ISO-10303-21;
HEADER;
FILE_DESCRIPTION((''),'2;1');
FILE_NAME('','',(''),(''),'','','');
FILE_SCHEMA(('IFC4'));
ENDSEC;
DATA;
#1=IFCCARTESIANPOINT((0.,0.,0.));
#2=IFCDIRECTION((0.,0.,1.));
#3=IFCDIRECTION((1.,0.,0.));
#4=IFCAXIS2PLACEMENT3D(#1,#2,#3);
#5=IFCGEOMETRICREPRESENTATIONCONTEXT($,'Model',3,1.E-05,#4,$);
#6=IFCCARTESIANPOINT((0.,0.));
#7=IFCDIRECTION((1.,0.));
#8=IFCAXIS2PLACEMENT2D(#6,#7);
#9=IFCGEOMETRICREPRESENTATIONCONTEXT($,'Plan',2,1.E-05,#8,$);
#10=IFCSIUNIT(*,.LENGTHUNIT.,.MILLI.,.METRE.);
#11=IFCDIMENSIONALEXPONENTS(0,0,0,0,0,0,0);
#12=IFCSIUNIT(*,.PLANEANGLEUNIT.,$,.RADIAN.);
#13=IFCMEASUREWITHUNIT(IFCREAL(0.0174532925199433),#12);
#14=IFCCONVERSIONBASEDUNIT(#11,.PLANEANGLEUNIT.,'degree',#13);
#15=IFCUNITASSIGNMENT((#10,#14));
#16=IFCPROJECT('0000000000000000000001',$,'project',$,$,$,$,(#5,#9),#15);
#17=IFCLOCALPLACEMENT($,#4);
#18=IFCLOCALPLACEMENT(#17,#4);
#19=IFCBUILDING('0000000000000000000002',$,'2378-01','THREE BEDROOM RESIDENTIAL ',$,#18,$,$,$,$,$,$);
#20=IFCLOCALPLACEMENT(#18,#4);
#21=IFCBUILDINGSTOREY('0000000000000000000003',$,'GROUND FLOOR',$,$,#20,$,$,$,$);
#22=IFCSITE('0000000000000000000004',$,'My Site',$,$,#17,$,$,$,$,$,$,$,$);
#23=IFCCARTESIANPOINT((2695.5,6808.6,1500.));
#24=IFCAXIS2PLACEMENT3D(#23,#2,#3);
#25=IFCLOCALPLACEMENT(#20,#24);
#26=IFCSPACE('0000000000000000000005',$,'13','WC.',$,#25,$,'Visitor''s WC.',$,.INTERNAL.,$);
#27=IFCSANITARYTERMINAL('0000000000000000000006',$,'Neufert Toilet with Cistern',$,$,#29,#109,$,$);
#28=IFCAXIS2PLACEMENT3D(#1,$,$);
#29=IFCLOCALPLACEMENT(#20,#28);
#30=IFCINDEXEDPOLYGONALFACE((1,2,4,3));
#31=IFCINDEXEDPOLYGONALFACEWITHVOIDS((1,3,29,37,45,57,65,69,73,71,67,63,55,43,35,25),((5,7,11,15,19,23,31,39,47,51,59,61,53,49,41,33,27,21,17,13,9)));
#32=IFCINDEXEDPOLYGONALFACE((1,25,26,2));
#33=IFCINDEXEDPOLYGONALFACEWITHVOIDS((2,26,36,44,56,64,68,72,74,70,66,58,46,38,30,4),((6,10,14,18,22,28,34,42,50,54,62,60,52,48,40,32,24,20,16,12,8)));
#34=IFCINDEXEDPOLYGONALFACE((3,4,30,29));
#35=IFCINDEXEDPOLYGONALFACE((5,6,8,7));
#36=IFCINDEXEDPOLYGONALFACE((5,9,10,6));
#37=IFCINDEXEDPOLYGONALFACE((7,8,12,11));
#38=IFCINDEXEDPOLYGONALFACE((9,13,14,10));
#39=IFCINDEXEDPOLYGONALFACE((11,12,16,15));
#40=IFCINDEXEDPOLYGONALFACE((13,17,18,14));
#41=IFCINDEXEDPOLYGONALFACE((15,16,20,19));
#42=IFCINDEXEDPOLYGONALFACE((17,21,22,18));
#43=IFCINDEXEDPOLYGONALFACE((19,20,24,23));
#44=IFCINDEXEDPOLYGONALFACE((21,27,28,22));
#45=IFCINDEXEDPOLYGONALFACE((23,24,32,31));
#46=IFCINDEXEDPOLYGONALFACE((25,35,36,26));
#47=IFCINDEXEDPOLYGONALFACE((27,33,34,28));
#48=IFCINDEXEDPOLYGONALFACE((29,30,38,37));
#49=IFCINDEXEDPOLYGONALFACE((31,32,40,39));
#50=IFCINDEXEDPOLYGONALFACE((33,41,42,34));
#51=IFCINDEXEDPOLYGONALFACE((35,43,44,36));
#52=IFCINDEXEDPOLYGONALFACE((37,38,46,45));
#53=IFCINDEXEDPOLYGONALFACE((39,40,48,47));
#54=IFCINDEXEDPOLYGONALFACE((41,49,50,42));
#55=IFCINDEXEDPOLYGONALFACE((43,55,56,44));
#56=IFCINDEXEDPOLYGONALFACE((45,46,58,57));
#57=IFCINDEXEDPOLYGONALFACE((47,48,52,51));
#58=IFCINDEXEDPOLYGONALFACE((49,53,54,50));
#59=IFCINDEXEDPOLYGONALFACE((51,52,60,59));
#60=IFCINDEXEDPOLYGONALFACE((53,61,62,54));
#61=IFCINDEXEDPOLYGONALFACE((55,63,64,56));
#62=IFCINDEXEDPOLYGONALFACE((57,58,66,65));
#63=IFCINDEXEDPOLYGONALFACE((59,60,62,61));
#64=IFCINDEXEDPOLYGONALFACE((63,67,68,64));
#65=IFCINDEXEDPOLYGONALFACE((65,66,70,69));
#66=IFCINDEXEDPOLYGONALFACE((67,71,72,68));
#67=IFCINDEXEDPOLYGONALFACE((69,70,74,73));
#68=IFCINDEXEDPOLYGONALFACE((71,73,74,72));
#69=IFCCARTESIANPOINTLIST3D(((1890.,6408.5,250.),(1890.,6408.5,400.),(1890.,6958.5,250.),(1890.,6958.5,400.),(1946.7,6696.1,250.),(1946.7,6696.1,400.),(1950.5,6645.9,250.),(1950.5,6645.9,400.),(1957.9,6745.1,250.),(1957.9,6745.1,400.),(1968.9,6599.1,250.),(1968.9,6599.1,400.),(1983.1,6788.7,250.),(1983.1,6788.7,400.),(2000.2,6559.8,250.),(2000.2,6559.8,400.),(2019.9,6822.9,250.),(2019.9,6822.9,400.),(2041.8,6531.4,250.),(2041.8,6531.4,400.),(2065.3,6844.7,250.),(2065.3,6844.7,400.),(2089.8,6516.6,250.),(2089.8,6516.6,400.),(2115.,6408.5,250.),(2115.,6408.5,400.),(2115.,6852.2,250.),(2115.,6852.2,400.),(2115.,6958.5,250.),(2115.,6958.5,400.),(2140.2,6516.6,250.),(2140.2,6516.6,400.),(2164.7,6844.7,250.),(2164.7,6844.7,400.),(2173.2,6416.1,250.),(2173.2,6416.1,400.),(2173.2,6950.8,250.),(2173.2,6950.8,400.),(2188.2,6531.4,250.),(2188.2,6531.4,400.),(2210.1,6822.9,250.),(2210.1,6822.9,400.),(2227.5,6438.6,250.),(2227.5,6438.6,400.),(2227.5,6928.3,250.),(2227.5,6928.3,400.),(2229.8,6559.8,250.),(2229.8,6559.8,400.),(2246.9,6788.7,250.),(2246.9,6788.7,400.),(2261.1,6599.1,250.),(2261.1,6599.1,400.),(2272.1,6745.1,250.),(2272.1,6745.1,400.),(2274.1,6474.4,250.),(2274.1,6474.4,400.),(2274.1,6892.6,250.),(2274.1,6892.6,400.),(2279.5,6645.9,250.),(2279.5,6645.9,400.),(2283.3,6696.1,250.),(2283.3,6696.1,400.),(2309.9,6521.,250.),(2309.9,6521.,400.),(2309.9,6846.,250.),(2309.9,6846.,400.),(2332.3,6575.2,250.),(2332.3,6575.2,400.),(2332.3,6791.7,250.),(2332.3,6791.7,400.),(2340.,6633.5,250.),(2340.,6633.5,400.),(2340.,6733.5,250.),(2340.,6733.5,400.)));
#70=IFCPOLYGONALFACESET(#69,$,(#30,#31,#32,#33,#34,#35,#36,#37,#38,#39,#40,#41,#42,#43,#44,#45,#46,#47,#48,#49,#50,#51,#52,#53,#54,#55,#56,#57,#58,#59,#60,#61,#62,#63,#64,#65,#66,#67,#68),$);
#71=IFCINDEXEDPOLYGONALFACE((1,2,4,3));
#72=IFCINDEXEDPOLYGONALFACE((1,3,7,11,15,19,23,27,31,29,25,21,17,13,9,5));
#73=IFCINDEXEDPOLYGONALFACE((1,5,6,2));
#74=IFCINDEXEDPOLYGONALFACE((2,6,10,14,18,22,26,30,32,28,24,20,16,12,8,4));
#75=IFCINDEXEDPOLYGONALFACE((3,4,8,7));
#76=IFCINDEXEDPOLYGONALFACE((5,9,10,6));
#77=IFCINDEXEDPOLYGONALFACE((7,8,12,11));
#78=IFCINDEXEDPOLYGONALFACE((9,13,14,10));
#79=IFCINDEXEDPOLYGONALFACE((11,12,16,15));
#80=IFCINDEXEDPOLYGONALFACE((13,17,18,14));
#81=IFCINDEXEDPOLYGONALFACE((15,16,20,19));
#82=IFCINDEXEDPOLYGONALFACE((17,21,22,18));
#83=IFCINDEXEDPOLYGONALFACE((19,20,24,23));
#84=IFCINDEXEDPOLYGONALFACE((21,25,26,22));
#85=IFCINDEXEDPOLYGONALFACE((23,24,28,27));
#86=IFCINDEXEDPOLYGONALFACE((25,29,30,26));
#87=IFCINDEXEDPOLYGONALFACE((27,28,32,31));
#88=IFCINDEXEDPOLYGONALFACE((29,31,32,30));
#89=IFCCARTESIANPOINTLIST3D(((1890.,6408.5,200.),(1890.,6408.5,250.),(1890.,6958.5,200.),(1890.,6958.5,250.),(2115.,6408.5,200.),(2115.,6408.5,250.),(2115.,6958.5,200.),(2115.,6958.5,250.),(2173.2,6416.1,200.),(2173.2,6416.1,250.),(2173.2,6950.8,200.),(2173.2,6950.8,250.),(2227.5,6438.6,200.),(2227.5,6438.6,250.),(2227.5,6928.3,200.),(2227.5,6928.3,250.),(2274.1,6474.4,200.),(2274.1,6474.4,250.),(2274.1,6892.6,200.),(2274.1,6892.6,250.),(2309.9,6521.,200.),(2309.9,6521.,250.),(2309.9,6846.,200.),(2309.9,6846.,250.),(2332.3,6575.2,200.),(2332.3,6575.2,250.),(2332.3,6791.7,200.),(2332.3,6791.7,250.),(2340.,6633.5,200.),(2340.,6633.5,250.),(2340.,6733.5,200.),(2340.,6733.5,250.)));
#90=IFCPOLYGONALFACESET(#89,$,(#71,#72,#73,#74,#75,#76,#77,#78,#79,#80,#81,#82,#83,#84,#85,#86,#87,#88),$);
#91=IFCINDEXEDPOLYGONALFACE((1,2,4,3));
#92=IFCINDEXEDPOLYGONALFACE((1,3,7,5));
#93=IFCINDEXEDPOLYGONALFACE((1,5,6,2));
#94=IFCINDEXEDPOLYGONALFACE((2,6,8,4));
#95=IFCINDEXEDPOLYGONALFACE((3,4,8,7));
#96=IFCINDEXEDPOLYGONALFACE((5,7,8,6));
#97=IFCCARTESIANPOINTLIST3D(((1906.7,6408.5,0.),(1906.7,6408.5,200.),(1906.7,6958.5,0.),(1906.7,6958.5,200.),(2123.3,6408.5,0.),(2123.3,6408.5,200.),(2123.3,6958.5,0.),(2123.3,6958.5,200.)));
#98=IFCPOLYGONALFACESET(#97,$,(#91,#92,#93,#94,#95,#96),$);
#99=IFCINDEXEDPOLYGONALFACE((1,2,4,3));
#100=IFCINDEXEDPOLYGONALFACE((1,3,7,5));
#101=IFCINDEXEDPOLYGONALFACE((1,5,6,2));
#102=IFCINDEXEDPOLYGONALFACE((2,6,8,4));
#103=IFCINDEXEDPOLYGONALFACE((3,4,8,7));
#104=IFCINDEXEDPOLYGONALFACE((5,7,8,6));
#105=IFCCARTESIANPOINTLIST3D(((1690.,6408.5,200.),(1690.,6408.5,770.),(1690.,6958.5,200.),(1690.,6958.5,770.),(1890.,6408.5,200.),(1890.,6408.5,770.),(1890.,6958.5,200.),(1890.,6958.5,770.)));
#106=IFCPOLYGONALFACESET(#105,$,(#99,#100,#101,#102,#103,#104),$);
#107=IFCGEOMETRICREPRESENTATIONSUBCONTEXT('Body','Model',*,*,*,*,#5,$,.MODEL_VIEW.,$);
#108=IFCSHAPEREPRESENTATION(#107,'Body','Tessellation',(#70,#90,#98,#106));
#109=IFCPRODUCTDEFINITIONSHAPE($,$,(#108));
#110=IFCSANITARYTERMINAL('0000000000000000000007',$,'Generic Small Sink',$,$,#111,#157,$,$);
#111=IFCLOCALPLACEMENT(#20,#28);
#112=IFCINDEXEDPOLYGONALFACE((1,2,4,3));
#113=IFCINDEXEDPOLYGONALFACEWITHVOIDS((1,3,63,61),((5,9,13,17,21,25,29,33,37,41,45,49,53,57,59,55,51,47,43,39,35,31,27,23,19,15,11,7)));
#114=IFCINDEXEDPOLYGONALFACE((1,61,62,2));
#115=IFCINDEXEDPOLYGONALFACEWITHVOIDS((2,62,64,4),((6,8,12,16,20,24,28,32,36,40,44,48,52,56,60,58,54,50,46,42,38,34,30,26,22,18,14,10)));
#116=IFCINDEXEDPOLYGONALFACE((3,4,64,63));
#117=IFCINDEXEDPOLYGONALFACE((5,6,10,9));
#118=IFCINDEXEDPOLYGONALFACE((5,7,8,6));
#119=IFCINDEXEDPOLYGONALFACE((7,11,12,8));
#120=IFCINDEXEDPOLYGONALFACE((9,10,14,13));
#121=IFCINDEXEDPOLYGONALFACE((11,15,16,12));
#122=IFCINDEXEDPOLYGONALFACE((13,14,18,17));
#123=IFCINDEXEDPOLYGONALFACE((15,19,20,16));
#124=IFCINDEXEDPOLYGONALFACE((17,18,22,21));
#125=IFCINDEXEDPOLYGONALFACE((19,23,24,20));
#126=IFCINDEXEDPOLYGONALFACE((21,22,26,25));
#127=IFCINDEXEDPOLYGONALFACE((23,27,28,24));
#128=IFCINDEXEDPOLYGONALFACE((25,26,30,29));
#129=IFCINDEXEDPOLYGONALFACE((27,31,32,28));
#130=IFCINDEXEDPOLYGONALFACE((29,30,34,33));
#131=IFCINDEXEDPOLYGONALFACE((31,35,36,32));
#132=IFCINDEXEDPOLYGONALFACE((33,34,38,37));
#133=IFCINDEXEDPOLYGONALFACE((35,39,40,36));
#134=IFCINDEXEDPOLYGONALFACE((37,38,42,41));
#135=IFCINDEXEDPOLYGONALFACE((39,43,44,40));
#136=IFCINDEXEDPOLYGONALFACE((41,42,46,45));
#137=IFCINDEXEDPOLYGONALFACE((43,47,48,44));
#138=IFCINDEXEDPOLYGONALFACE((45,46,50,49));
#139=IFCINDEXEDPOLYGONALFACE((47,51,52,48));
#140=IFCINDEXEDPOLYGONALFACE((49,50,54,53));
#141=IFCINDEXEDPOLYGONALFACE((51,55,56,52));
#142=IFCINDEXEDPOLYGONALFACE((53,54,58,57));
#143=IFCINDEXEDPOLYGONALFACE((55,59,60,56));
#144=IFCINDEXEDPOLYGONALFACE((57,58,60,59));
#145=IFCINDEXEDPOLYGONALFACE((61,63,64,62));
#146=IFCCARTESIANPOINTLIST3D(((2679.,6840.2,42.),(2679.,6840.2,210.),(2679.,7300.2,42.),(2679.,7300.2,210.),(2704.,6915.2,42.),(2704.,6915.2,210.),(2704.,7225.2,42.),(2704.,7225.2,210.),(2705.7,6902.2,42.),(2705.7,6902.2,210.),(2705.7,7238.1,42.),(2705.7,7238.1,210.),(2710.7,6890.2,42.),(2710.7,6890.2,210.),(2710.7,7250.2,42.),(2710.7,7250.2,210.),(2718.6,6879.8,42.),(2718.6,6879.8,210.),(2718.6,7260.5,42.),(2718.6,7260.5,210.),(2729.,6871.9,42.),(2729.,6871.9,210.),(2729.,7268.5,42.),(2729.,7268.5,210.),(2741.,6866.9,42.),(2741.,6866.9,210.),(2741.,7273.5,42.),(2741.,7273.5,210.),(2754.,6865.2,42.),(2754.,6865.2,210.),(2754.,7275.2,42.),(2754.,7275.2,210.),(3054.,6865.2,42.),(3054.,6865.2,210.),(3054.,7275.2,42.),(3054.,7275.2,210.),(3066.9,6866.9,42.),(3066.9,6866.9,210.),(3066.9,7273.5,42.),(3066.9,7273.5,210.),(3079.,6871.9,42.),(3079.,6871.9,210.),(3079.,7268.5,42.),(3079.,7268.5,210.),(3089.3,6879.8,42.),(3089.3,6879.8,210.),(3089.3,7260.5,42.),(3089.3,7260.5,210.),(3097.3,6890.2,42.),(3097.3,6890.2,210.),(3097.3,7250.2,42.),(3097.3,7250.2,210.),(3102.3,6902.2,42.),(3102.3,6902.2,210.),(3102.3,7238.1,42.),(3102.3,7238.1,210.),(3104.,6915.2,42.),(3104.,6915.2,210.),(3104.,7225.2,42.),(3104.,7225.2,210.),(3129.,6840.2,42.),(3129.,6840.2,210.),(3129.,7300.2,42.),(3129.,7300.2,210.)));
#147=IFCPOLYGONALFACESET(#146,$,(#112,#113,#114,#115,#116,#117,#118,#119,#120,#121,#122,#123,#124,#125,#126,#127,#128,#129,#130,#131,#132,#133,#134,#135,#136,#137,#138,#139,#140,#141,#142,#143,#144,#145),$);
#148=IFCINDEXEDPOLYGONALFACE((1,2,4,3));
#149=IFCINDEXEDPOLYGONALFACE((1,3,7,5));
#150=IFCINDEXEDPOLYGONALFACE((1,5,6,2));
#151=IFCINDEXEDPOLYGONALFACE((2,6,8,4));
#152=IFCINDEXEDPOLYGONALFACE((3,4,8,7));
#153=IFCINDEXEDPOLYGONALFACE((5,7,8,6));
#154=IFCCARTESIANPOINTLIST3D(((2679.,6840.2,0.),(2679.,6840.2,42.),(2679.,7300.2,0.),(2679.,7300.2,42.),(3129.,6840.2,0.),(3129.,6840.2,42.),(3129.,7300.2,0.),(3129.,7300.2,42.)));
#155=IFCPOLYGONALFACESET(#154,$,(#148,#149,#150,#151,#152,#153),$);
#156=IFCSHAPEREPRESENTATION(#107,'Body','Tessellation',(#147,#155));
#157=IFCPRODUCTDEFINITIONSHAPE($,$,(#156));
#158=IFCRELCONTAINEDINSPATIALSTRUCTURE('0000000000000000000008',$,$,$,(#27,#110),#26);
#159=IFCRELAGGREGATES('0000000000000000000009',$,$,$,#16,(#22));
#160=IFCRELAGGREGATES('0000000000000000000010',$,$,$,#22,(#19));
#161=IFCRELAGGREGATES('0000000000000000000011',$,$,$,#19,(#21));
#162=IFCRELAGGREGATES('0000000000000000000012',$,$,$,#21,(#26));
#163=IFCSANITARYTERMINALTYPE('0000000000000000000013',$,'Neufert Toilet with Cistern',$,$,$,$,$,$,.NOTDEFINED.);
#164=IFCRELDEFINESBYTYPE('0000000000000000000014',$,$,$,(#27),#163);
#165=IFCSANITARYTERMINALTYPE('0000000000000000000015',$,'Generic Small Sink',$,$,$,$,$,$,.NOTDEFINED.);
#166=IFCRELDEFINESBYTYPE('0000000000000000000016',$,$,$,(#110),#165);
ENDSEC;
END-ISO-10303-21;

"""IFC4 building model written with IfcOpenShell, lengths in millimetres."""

from ifc_helpers import new_model, entity, si_unit, converted_unit, frame, frame_2d, origin_with_axes, origin_2d_with_axis, place, context, subcontext, project, spatial, line, arc, indexed_curve, circle_curve, outline, extrude, shape, source, transform, mapped, type_object, type_shapes, element, save


model = new_model("IFC4")

# Units and contexts
model_context = context("Model", 3, precision=1e-05, world=origin_with_axes())
plan_context = context("Plan", 2, precision=1e-05, world=origin_2d_with_axis())
body_context_1 = subcontext(model_context, "Body", "Model", "MODEL_VIEW")
body_context_2 = subcontext(plan_context, "Body", "Plan", "PLAN_VIEW")
ifc_project = project(units=[si_unit("LENGTHUNIT", "METRE", prefix="MILLI"), converted_unit("PLANEANGLEUNIT", "degree", entity("IfcReal", 0.0174532925199433), si_unit("PLANEANGLEUNIT", "RADIAN"), dimensions=[0, 0, 0, 0, 0, 0, 0])], contexts=[model_context, plan_context])

# Site, building, storey
site_placement = place(None, origin_with_axes())
site = spatial("IfcSite", under=ifc_project, at=site_placement, Name="My Site")
building_placement = place(site_placement, origin_with_axes())
building = spatial("IfcBuilding", under=site, at=building_placement, Name="2378-01", Description="THREE BEDROOM RESIDENTIAL ")
storey_placement = place(building_placement, origin_with_axes())
storey = spatial("IfcBuildingStorey", under=building, at=storey_placement, Name="GROUND FLOOR")

# Shared definitions
space_1_placement = place(storey_placement, frame((2695.5, 6808.6, 1500.0), z_axis=(0.0, 0.0, 1.0), x_axis=(1.0, 0.0, 0.0)))
space_1 = spatial("IfcSpace", under=storey, at=space_1_placement, Name="13", Description="WC.", LongName="Visitor's WC.", PredefinedType="INTERNAL")

# Sanitary terminals
sanitary_terminal_type_1 = type_object("IfcSanitaryTerminalType", Name="Neufert Toilet with Cistern", PredefinedType="NOTDEFINED")
shared_shape_1 = source(origin_with_axes(), body_context_1, "Body", "SweptSolid", [
    extrude(outline(indexed_curve([(-275.0, -200.0), (275.0, -200.0), (275.0, -425.0), (209.1, -584.1), (50.0, -650.0), (-50.0, -650.0), (-209.1, -584.1), (-275.0, -425.0)], segments=[line(1, 2), line(2, 3), arc(3, 4, 5), line(5, 6), arc(6, 7, 8), line(8, 1)]), holes=[circle_curve(frame_2d((0.0, -425.0)), 168.8)]), frame((0.0, 0.0, 250.0), z_axis=(0.0, 0.0, 1.0), x_axis=(1.0, 0.0, 0.0)), (0.0, 0.0, 1.0), 150.0),
    extrude(outline(indexed_curve([(-275.0, -200.0), (275.0, -200.0), (275.0, -425.0), (209.1, -584.1), (50.0, -650.0), (-50.0, -650.0), (-209.1, -584.1), (-275.0, -425.0)], segments=[line(1, 2), line(2, 3), arc(3, 4, 5), line(5, 6), arc(6, 7, 8), line(8, 1)])), frame((0.0, 0.0, 200.0), z_axis=(0.0, 0.0, 1.0), x_axis=(1.0, 0.0, 0.0)), (0.0, 0.0, 1.0), 50.0),
    extrude(outline(indexed_curve([(-275.0, -216.7), (275.0, -216.7), (275.0, -433.3), (-275.0, -433.3)], segments=[line(1, 2, 3, 4, 1)])), origin_with_axes(), (0.0, 0.0, 1.0), 200.0),
    extrude(outline(indexed_curve([(-275.0, 0.0), (275.0, 0.0), (275.0, -200.0), (-275.0, -200.0)], segments=[line(1, 2, 3, 4, 1)])), frame((0.0, 0.0, 200.0), z_axis=(0.0, 0.0, 1.0), x_axis=(1.0, 0.0, 0.0)), (0.0, 0.0, 1.0), 570.0),
])
shared_shape_2 = source(origin_with_axes(), body_context_2, "Body", "Curve2D", [
    entity("IfcIndexedPolyCurve", entity("IfcCartesianPointList2D", [[-275.0, 0.0], [275.0, 0.0], [275.0, -200.0], [-275.0, -200.0]]), [entity("IfcLineIndex", [1, 2, 3, 4, 1])]),
    entity("IfcIndexedPolyCurve", entity("IfcCartesianPointList2D", [[165.0, -200.0], [192.5, -335.0]])),
    entity("IfcTrimmedCurve", entity("IfcEllipse", entity("IfcAxis2Placement2D", entity("IfcCartesianPoint", [0.0, -335.0]), entity("IfcDirection", [1.0, 0.0])), 192.5, 315.0), [entity("IfcCartesianPoint", [-192.5, -335.0])], [entity("IfcCartesianPoint", [192.5, -335.0])], True, "CARTESIAN"),
    entity("IfcIndexedPolyCurve", entity("IfcCartesianPointList2D", [[-165.0, -200.0], [-192.5, -335.0]])),
    entity("IfcEllipse", entity("IfcAxis2Placement2D", entity("IfcCartesianPoint", [0.0, -452.0]), entity("IfcDirection", [1.0, 0.0])), 131.2, 157.5),
    entity("IfcIndexedPolyCurve", entity("IfcCartesianPointList2D", [[-34.4, -452.0], [-34.4, -429.5], [34.4, -429.5], [34.4, -452.0]])),
    entity("IfcTrimmedCurve", entity("IfcEllipse", entity("IfcAxis2Placement2D", entity("IfcCartesianPoint", [0.0, -452.0]), entity("IfcDirection", [1.0, 0.0])), 34.4, 22.5), [entity("IfcCartesianPoint", [-34.4, -452.0])], [entity("IfcCartesianPoint", [34.4, -452.0])], True, "CARTESIAN"),
])
type_shapes(sanitary_terminal_type_1, [shared_shape_1, shared_shape_2])
sanitary_terminal_1_placement = place(space_1_placement, frame((-1005.5, -125.1, -1500.0), z_axis=(0.0, 0.0, 1.0), x_axis=(0.0, 1.0, 0.0)))
element("IfcSanitaryTerminal", 1, at=sanitary_terminal_1_placement, inside=space_1, type_object=sanitary_terminal_type_1, Name="Neufert Toilet with Cistern", shapes=[
    shape(body_context_1, "Body", "MappedRepresentation", [mapped(shared_shape_1, transform((0.0, 0.0, 0.0), x_axis=(1.0, 0.0, 0.0), y_axis=(0.0, 1.0, 0.0), z_axis=(0.0, 0.0, 1.0), scale=1.0))]),
    shape(body_context_2, "Body", "MappedRepresentation", [mapped(shared_shape_2, transform((0.0, 0.0, 0.0), x_axis=(1.0, 0.0, 0.0), y_axis=(0.0, 1.0, 0.0), z_axis=(0.0, 0.0, 1.0), scale=1.0))]),
])
sanitary_terminal_type_2 = type_object("IfcSanitaryTerminalType", Name="Generic Small Sink", PredefinedType="NOTDEFINED")
shared_indexed_poly_curve = entity("IfcIndexedPolyCurve", entity("IfcCartesianPointList2D", [[0.0, 0.0], [450.0, 0.0], [450.0, 460.0], [0.0, 460.0]]), [entity("IfcLineIndex", [1, 2, 3, 4, 1])])
shared_shape_3 = source(origin_with_axes(), body_context_1, "Body", "SweptSolid", [
    entity("IfcExtrudedAreaSolid", entity("IfcArbitraryProfileDefWithVoids", "AREA", None, shared_indexed_poly_curve, [entity("IfcIndexedPolyCurve", entity("IfcCartesianPointList2D", [[25.0, 75.0], [39.6, 39.6], [75.0, 25.0], [375.0, 25.0], [410.4, 39.6], [425.0, 75.0], [425.0, 385.0], [410.4, 420.4], [375.0, 435.0], [75.0, 435.0], [39.6, 420.4], [25.0, 385.0]]), [entity("IfcLineIndex", [12, 1]), entity("IfcArcIndex", [1, 2, 3]), entity("IfcLineIndex", [3, 4]), entity("IfcArcIndex", [4, 5, 6]), entity("IfcLineIndex", [6, 7]), entity("IfcArcIndex", [7, 8, 9]), entity("IfcLineIndex", [9, 10]), entity("IfcArcIndex", [10, 11, 12]), entity("IfcLineIndex", [12, 1])])]), entity("IfcAxis2Placement3D", entity("IfcCartesianPoint", [-225.0, -460.0, 42.0]), entity("IfcDirection", [0.0, 0.0, 1.0]), entity("IfcDirection", [1.0, 0.0, 0.0])), entity("IfcDirection", [0.0, 0.0, 1.0]), 168.0),
    entity("IfcExtrudedAreaSolid", entity("IfcArbitraryClosedProfileDef", "AREA", None, shared_indexed_poly_curve), entity("IfcAxis2Placement3D", entity("IfcCartesianPoint", [-225.0, -460.0, 0.0]), entity("IfcDirection", [0.0, 0.0, 1.0]), entity("IfcDirection", [1.0, 0.0, 0.0])), entity("IfcDirection", [0.0, 0.0, 1.0]), 42.0),
])
shared_shape_4 = source(origin_with_axes(), body_context_2, "Body", "Curve2D", [
    entity("IfcIndexedPolyCurve", entity("IfcCartesianPointList2D", [[-225.0, -460.0], [225.0, -460.0], [225.0, 0.0], [-225.0, 0.0]]), [entity("IfcLineIndex", [1, 2, 3, 4, 1])]),
    entity("IfcIndexedPolyCurve", entity("IfcCartesianPointList2D", [[-200.0, -385.0], [-185.4, -420.4], [-150.0, -435.0], [150.0, -435.0], [185.4, -420.4], [200.0, -385.0], [200.0, -75.0], [185.4, -39.6], [150.0, -25.0], [-150.0, -25.0], [-185.4, -39.6], [-200.0, -75.0]]), [entity("IfcLineIndex", [12, 1]), entity("IfcArcIndex", [1, 2, 3]), entity("IfcLineIndex", [3, 4]), entity("IfcArcIndex", [4, 5, 6]), entity("IfcLineIndex", [6, 7]), entity("IfcArcIndex", [7, 8, 9]), entity("IfcLineIndex", [9, 10]), entity("IfcArcIndex", [10, 11, 12]), entity("IfcLineIndex", [12, 1])]),
    entity("IfcCircle", entity("IfcAxis2Placement2D", entity("IfcCartesianPoint", [0.0, -125.0])), 25.0),
    entity("IfcIndexedPolyCurve", entity("IfcCartesianPointList2D", [[0.0, -12.5], [0.0, -132.5]])),
])
type_shapes(sanitary_terminal_type_2, [shared_shape_3, shared_shape_4])
sanitary_terminal_2_placement = place(space_1_placement, frame((208.5, 491.6, -1500.0), z_axis=(0.0, 0.0, 1.0), x_axis=(1.0, 0.000001, 0.0)))
element("IfcSanitaryTerminal", 2, at=sanitary_terminal_2_placement, inside=space_1, type_object=sanitary_terminal_type_2, Name="Generic Small Sink", shapes=[
    shape(body_context_1, "Body", "MappedRepresentation", [mapped(shared_shape_3, transform((0.0, 0.0, 0.0), x_axis=(1.0, 0.0, 0.0), y_axis=(0.0, 1.0, 0.0), z_axis=(0.0, 0.0, 1.0), scale=1.0))]),
    shape(body_context_2, "Body", "MappedRepresentation", [mapped(shared_shape_4, transform((0.0, 0.0, 0.0), x_axis=(1.0, 0.0, 0.0), y_axis=(0.0, 1.0, 0.0), z_axis=(0.0, 0.0, 1.0), scale=1.0))]),
])

save(model, "model.ifc")
